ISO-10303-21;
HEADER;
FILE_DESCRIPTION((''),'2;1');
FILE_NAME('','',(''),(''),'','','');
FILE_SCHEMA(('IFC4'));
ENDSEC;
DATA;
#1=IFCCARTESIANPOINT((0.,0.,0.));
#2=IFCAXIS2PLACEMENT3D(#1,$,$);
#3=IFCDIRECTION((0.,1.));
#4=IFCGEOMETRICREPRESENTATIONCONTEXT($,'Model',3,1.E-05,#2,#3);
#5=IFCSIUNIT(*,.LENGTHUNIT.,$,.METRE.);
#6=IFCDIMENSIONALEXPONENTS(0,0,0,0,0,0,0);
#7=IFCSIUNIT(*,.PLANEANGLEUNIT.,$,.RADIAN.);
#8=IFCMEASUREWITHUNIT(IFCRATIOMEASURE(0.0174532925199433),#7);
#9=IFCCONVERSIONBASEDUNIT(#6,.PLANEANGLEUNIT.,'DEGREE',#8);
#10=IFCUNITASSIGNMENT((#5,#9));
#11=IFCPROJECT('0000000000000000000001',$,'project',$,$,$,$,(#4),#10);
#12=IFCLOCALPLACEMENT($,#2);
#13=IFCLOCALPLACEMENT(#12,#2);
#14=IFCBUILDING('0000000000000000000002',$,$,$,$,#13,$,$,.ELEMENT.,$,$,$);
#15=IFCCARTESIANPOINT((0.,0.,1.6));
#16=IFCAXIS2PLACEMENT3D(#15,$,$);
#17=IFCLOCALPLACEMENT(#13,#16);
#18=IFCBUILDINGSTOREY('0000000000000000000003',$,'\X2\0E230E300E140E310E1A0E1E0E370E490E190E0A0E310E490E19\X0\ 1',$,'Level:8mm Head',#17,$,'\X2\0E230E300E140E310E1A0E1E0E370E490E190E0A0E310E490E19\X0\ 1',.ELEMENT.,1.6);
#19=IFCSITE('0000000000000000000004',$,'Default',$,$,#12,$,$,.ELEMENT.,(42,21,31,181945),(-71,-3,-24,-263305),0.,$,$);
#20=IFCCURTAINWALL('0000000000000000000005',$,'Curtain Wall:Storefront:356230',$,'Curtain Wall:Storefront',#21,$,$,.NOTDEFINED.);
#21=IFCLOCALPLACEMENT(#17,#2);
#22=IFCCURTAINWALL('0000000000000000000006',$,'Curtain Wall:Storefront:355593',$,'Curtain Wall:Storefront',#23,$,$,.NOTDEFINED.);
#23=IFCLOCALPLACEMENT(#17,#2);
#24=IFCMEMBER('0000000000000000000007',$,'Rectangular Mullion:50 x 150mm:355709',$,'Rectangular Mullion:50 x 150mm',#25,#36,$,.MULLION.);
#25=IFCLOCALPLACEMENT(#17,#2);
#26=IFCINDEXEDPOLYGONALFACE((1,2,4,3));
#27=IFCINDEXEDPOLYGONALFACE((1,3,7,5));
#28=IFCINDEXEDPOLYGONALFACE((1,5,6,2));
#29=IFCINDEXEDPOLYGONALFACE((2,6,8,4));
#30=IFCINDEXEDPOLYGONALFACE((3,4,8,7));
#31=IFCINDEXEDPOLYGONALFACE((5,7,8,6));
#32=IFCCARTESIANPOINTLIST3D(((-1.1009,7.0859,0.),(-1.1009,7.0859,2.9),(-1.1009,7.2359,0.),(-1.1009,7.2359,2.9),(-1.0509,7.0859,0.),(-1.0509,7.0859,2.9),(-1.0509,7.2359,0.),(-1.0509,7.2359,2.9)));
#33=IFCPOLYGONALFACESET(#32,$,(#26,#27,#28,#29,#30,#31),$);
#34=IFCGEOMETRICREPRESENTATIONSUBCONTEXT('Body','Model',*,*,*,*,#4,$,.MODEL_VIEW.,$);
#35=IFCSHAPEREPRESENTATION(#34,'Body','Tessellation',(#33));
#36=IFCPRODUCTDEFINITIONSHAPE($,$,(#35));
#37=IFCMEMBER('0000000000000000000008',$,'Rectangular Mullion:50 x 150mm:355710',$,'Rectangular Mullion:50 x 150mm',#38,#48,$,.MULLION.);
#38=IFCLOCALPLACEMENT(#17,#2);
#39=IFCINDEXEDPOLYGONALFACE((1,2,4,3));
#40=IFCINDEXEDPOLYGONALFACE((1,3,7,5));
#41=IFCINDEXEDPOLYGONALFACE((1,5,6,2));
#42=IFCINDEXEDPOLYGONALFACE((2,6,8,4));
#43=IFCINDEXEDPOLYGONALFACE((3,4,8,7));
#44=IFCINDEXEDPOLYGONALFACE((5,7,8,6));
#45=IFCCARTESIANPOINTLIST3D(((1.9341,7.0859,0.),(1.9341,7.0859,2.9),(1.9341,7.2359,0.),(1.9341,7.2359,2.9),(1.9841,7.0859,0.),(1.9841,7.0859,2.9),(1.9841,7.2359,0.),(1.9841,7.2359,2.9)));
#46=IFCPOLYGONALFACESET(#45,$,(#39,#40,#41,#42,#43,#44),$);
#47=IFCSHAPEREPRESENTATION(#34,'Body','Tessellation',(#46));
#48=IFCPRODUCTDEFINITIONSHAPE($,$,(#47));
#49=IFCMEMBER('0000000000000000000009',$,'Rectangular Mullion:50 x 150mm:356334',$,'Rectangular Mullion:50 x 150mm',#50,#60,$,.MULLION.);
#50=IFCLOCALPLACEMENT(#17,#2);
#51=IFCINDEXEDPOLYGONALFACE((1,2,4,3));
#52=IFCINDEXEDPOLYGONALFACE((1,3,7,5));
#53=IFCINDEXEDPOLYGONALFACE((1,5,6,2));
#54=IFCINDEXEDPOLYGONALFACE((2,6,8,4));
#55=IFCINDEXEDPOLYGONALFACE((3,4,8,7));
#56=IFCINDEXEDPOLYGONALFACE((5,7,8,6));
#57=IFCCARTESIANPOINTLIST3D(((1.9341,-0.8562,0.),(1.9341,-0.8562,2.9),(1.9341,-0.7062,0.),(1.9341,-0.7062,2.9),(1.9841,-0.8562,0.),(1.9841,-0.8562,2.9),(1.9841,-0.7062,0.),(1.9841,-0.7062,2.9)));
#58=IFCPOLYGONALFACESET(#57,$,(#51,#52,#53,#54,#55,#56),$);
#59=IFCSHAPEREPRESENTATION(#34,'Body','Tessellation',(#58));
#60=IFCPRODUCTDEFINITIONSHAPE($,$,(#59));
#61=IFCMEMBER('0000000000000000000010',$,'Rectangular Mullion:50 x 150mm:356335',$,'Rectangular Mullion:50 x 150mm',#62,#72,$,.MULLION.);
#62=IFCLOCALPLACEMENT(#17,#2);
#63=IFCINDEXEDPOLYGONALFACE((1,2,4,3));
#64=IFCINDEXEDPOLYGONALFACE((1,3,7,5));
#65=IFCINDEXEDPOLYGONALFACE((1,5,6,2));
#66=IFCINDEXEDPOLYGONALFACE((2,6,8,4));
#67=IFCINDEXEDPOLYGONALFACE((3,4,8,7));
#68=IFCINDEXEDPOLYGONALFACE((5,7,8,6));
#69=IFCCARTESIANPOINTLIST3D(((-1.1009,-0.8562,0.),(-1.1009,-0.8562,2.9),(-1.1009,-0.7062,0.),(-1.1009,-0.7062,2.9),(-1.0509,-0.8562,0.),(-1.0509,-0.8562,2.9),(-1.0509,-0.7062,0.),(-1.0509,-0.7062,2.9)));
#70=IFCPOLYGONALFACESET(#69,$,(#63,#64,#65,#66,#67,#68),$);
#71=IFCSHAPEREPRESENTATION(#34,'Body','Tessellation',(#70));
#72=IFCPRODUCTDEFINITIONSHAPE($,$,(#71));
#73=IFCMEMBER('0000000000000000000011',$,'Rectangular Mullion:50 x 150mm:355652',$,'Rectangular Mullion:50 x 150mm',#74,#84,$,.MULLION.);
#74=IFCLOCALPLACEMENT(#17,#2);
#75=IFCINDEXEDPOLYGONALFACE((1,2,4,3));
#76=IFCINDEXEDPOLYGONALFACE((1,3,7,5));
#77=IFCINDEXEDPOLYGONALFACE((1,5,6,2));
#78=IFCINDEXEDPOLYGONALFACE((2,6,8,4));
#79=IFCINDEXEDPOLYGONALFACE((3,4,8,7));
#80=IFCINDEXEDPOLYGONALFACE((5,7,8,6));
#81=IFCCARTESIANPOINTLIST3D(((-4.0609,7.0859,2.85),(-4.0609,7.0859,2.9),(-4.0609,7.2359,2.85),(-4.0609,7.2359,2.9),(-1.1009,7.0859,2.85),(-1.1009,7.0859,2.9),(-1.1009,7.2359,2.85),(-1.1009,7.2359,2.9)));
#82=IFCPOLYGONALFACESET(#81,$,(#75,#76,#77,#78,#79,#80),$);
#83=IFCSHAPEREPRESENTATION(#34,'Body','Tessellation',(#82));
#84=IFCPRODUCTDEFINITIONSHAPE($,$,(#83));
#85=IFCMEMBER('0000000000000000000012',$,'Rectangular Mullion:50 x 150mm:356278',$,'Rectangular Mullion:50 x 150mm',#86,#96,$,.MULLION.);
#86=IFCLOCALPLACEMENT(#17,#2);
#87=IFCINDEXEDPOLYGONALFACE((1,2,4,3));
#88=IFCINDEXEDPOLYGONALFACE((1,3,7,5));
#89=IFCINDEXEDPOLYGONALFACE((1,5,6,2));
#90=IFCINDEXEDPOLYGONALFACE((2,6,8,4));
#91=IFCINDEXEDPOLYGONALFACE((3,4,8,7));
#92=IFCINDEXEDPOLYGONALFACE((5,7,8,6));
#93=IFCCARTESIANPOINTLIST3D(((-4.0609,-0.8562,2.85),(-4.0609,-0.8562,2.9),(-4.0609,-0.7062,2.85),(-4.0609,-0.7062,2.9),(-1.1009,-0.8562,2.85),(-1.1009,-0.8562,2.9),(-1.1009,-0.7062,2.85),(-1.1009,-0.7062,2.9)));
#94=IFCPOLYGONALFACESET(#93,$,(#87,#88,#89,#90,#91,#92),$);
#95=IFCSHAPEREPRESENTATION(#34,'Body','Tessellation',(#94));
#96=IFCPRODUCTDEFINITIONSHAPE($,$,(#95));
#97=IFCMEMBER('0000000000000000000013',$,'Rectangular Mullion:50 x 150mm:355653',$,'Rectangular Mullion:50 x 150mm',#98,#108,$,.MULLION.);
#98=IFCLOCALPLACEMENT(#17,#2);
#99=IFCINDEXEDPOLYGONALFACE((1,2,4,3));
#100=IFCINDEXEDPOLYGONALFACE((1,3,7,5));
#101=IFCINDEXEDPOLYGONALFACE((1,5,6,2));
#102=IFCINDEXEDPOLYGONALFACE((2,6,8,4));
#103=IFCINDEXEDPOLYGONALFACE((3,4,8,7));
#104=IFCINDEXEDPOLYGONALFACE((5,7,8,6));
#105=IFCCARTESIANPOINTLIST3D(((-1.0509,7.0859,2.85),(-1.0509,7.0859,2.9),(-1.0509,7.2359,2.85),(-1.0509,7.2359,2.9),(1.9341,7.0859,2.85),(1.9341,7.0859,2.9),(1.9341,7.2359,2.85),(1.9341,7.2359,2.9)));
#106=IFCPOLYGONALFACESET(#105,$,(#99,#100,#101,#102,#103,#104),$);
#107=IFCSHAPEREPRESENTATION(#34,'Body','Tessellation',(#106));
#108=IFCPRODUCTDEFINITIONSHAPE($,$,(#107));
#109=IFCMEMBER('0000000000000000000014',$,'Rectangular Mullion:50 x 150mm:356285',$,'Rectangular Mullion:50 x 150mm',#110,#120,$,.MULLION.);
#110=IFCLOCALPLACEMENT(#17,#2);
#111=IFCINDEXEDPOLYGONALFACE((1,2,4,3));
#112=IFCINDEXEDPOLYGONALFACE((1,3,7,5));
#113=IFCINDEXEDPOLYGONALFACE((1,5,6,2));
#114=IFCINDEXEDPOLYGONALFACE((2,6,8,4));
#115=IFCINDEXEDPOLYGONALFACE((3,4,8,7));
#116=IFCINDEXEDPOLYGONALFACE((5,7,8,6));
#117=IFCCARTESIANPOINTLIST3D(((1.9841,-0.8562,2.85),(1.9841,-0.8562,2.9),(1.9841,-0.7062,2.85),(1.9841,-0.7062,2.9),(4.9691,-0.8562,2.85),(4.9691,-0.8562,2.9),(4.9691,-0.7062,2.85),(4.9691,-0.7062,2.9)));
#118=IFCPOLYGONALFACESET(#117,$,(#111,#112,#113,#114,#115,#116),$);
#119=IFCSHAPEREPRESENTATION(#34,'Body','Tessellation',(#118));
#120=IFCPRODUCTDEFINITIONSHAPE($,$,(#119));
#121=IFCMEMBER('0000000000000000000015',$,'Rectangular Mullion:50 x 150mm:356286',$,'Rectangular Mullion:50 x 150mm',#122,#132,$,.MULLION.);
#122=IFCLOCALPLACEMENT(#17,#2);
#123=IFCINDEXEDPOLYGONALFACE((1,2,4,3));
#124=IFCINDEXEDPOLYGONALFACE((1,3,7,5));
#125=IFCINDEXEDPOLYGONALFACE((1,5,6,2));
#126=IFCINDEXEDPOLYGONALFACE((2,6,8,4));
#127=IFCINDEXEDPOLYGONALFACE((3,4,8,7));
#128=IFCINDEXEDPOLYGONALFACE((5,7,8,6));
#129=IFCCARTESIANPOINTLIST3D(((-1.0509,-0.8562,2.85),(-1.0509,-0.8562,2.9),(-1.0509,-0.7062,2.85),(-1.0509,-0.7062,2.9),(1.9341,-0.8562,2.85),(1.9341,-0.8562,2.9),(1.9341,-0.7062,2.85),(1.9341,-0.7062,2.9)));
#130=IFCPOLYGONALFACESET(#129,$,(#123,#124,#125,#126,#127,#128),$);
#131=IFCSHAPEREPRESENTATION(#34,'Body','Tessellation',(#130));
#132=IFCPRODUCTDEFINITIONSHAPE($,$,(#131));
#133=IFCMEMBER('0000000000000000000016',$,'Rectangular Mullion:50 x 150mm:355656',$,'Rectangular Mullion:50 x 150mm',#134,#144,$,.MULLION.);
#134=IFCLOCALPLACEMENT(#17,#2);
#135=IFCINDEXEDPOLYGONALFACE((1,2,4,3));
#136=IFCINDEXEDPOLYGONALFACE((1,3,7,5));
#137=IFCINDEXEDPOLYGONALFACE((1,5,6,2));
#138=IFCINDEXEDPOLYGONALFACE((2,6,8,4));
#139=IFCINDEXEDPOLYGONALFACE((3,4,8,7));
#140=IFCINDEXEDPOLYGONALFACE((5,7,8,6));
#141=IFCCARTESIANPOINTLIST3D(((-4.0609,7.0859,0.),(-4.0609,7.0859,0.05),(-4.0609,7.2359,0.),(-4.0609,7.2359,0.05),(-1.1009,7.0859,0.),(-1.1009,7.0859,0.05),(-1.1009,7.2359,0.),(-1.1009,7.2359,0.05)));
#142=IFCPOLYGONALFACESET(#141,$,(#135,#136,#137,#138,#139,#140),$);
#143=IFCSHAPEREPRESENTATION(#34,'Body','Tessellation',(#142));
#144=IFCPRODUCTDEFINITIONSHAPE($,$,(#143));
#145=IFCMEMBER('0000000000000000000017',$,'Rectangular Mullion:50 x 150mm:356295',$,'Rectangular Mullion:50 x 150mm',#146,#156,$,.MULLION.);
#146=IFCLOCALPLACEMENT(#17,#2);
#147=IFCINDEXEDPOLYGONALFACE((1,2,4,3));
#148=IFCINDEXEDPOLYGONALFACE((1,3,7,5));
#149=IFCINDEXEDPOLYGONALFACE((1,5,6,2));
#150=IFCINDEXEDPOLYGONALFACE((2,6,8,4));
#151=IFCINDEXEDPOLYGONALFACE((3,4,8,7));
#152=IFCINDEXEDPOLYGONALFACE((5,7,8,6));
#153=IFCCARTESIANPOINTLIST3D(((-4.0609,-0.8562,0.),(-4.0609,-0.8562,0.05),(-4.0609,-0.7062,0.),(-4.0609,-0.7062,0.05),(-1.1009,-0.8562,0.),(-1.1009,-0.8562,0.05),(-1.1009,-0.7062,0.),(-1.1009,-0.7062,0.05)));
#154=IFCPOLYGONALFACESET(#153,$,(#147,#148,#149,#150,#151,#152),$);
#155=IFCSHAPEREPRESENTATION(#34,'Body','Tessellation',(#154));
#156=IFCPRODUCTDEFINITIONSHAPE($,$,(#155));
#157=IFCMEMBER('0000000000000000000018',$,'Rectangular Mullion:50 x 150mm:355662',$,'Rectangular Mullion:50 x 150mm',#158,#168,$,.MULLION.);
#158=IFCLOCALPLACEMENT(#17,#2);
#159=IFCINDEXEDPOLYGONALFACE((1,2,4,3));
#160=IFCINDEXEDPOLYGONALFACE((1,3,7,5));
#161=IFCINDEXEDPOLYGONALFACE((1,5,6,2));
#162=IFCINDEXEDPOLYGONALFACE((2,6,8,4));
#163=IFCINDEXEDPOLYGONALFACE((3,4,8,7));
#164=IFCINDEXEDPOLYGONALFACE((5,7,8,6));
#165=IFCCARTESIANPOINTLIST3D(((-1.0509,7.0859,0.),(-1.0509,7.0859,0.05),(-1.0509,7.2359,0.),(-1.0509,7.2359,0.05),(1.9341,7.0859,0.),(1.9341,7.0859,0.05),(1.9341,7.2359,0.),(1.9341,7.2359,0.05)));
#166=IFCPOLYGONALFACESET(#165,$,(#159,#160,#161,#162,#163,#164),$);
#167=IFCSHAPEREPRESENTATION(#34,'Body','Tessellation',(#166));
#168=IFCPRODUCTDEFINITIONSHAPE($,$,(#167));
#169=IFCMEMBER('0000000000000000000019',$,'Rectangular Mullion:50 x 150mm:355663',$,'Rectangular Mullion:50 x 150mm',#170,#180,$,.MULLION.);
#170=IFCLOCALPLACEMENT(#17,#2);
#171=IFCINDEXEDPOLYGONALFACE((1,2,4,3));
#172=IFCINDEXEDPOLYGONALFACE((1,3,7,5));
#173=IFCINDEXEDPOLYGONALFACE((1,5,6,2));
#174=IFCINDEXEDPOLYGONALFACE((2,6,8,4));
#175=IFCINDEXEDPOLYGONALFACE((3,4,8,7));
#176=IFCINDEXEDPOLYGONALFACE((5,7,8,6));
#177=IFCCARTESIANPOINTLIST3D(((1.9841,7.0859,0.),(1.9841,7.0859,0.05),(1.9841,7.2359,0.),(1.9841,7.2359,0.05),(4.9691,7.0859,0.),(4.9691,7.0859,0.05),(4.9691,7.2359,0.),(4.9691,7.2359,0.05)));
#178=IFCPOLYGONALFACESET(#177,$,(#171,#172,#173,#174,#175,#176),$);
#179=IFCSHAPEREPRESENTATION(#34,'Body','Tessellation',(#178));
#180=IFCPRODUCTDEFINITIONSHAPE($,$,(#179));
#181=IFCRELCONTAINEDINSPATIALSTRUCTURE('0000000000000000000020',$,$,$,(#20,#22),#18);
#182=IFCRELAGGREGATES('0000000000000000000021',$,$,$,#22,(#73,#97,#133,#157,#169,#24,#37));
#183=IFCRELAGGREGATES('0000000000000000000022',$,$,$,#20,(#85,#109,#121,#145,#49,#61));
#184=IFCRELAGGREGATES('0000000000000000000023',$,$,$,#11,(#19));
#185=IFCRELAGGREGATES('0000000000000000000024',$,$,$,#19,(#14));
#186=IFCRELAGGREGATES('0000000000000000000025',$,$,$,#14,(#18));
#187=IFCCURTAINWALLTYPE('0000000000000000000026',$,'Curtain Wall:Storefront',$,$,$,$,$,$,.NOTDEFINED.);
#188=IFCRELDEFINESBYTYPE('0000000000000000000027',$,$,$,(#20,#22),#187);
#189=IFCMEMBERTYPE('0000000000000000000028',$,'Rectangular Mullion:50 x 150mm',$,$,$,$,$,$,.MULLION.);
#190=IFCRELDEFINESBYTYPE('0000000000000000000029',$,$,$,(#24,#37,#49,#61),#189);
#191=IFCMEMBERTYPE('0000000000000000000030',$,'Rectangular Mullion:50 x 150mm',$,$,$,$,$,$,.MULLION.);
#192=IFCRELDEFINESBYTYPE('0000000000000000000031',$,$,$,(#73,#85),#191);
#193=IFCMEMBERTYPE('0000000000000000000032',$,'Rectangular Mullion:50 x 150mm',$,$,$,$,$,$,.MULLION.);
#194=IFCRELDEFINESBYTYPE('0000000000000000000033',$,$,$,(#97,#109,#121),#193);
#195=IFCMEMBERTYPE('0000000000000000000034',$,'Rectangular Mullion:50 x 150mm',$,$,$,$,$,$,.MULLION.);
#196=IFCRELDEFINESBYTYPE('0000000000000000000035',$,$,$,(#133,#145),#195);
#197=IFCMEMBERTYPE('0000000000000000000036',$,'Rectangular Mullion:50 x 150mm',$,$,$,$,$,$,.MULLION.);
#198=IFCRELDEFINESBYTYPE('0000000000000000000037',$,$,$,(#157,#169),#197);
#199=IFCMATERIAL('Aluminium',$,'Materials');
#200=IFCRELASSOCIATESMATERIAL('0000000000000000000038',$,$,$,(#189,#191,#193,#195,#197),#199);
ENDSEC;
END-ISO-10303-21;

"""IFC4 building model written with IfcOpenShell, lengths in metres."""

from ifc_helpers import new_model, entity, si_unit, converted_unit, direction, frame, origin, place, context, subcontext, project, spatial, indexed_curve, outline, extrude, source, transform, mapped, material, type_object, type_shapes, element, aggregate, save


model = new_model("IFC4")

# Units and contexts
model_context = context("Model", 3, precision=1e-05, world=origin(), true_north=direction((0.0, 1.0)))
body_context = subcontext(model_context, "Body", "Model", "MODEL_VIEW")
ifc_project = project(units=[si_unit("LENGTHUNIT", "METRE"), converted_unit("PLANEANGLEUNIT", "DEGREE", entity("IfcRatioMeasure", 0.0174532925199433), si_unit("PLANEANGLEUNIT", "RADIAN"), dimensions=[0, 0, 0, 0, 0, 0, 0])], contexts=[model_context])

# Site, building, storey
site_placement = place(None, origin())
site = spatial("IfcSite", under=ifc_project, at=site_placement, Name="Default", CompositionType="ELEMENT", RefLatitude=(42, 21, 31, 181945), RefLongitude=(-71, -3, -24, -263305), RefElevation=0.0)
building_placement = place(site_placement, origin())
building = spatial("IfcBuilding", under=site, at=building_placement, CompositionType="ELEMENT")
storey_placement = place(building_placement, frame((0.0, 0.0, 1.6)))
storey = spatial("IfcBuildingStorey", under=building, at=storey_placement, Name="ระดับพื้นชั้น 1", ObjectType="Level:8mm Head", LongName="ระดับพื้นชั้น 1", CompositionType="ELEMENT", Elevation=1.6)

# Shared definitions
curtain_wall_type = type_object("IfcCurtainWallType", Name="Curtain Wall:Storefront", PredefinedType="NOTDEFINED")
ifc_material_1 = material(Name="Aluminium", Category="Materials")

# Curtain wall
curtain_wall_1_placement = place(storey_placement, frame((0.0, 0.0, -1.6)))
curtain_wall_1 = element("IfcCurtainWall", 1, at=curtain_wall_1_placement, inside=storey, type_object=curtain_wall_type, Name="Curtain Wall:Storefront:356230", ObjectType="Curtain Wall:Storefront", PredefinedType="NOTDEFINED")

# Curtain wall
curtain_wall_2_placement = place(storey_placement, frame((0.0, 0.0, -1.6)))
curtain_wall_2 = element("IfcCurtainWall", 2, at=curtain_wall_2_placement, inside=storey, type_object=curtain_wall_type, Name="Curtain Wall:Storefront:355593", ObjectType="Curtain Wall:Storefront", PredefinedType="NOTDEFINED")

# Members
member_type_1 = type_object("IfcMemberType", Name="Rectangular Mullion:50 x 150mm", PredefinedType="MULLION", material=ifc_material_1)
shared_shape_1 = source(origin(), body_context, "Body", "SweptSolid", [
    extrude(outline(indexed_curve([(-0.075, -0.025), (0.075, -0.025), (0.075, 0.025), (-0.075, 0.025), (-0.075, -0.025)], self_intersect=False)), frame((0.0, 0.0, -2.9), z_axis=(0.0, 0.0, 1.0), x_axis=(0.0, -1.0, 0.0)), (0.0, 0.0, 1.0), 2.9),
])
type_shapes(member_type_1, [shared_shape_1])
member_1_placement = place(curtain_wall_2_placement, frame((-1.0759, 7.1609, 1.6), z_axis=(0.0, 0.0, -1.0), x_axis=(1.0, 0.0, 0.0)))
member_1 = element("IfcMember", 3, at=member_1_placement, type_object=member_type_1, Name="Rectangular Mullion:50 x 150mm:355709", ObjectType="Rectangular Mullion:50 x 150mm", PredefinedType="MULLION", context=body_context, shape_type="MappedRepresentation", body=[
    mapped(shared_shape_1, transform((0.0, 0.0, 0.0), scale=1.0)),
])
member_2_placement = place(curtain_wall_2_placement, frame((1.9591, 7.1609, 1.6), z_axis=(0.0, 0.0, -1.0), x_axis=(1.0, 0.0, 0.0)))
member_2 = element("IfcMember", 4, at=member_2_placement, type_object=member_type_1, Name="Rectangular Mullion:50 x 150mm:355710", ObjectType="Rectangular Mullion:50 x 150mm", PredefinedType="MULLION", context=body_context, shape_type="MappedRepresentation", body=[
    mapped(shared_shape_1, transform((0.0, 0.0, 0.0), scale=1.0)),
])
member_3_placement = place(curtain_wall_1_placement, frame((1.9591, -0.7812, 1.6), z_axis=(0.0, 0.0, -1.0), x_axis=(-1.0, 0.0, 0.0)))
member_3 = element("IfcMember", 5, at=member_3_placement, type_object=member_type_1, Name="Rectangular Mullion:50 x 150mm:356334", ObjectType="Rectangular Mullion:50 x 150mm", PredefinedType="MULLION", context=body_context, shape_type="MappedRepresentation", body=[
    mapped(shared_shape_1, transform((0.0, 0.0, 0.0), scale=1.0)),
])
member_4_placement = place(curtain_wall_1_placement, frame((-1.0759, -0.7812, 1.6), z_axis=(0.0, 0.0, -1.0), x_axis=(-1.0, 0.0, 0.0)))
member_4 = element("IfcMember", 6, at=member_4_placement, type_object=member_type_1, Name="Rectangular Mullion:50 x 150mm:356335", ObjectType="Rectangular Mullion:50 x 150mm", PredefinedType="MULLION", context=body_context, shape_type="MappedRepresentation", body=[
    mapped(shared_shape_1, transform((0.0, 0.0, 0.0), scale=1.0)),
])
member_type_2 = type_object("IfcMemberType", Name="Rectangular Mullion:50 x 150mm", PredefinedType="MULLION", material=ifc_material_1)
shared_shape_2 = source(origin(), body_context, "Body", "SweptSolid", [
    extrude(outline(indexed_curve([(-0.075, -0.025), (0.075, -0.025), (0.075, 0.025), (-0.075, 0.025), (-0.075, -0.025)], self_intersect=False)), frame((-0.025, 0.0, -2.96), z_axis=(0.0, 0.0, 1.0), x_axis=(0.0, -1.0, 0.0)), (0.0, 0.0, 1.0), 2.96),
])
type_shapes(member_type_2, [shared_shape_2])
member_5_placement = place(curtain_wall_2_placement, frame((-1.1009, 7.1609, 4.5), z_axis=(1.0, 0.0, 0.0), x_axis=(0.0, 0.0, 1.0)))
member_5 = element("IfcMember", 7, at=member_5_placement, type_object=member_type_2, Name="Rectangular Mullion:50 x 150mm:355652", ObjectType="Rectangular Mullion:50 x 150mm", PredefinedType="MULLION", context=body_context, shape_type="MappedRepresentation", body=[
    mapped(shared_shape_2, transform((0.0, 0.0, 0.0), scale=1.0)),
])
member_6_placement = place(curtain_wall_1_placement, frame((-4.0609, -0.7812, 4.5), z_axis=(-1.0, 0.0, 0.0), x_axis=(0.0, 0.0, 1.0)))
member_6 = element("IfcMember", 8, at=member_6_placement, type_object=member_type_2, Name="Rectangular Mullion:50 x 150mm:356278", ObjectType="Rectangular Mullion:50 x 150mm", PredefinedType="MULLION", context=body_context, shape_type="MappedRepresentation", body=[
    mapped(shared_shape_2, transform((0.0, 0.0, 0.0), scale=1.0)),
])
member_type_3 = type_object("IfcMemberType", Name="Rectangular Mullion:50 x 150mm", PredefinedType="MULLION", material=ifc_material_1)
shared_shape_3 = source(origin(), body_context, "Body", "SweptSolid", [
    extrude(outline(indexed_curve([(-0.075, -0.025), (0.075, -0.025), (0.075, 0.025), (-0.075, 0.025), (-0.075, -0.025)], self_intersect=False)), frame((-0.025, 0.0, -2.985), z_axis=(0.0, 0.0, 1.0), x_axis=(0.0, -1.0, 0.0)), (0.0, 0.0, 1.0), 2.985),
])
type_shapes(member_type_3, [shared_shape_3])
member_7_placement = place(curtain_wall_2_placement, frame((1.9341, 7.1609, 4.5), z_axis=(1.0, 0.0, 0.0), x_axis=(0.0, 0.0, 1.0)))
member_7 = element("IfcMember", 9, at=member_7_placement, type_object=member_type_3, Name="Rectangular Mullion:50 x 150mm:355653", ObjectType="Rectangular Mullion:50 x 150mm", PredefinedType="MULLION", context=body_context, shape_type="MappedRepresentation", body=[
    mapped(shared_shape_3, transform((0.0, 0.0, 0.0), scale=1.0)),
])
member_8_placement = place(curtain_wall_1_placement, frame((1.9841, -0.7812, 4.5), z_axis=(-1.0, 0.0, 0.0), x_axis=(0.0, 0.0, 1.0)))
member_8 = element("IfcMember", 10, at=member_8_placement, type_object=member_type_3, Name="Rectangular Mullion:50 x 150mm:356285", ObjectType="Rectangular Mullion:50 x 150mm", PredefinedType="MULLION", context=body_context, shape_type="MappedRepresentation", body=[
    mapped(shared_shape_3, transform((0.0, 0.0, 0.0), scale=1.0)),
])
member_9_placement = place(curtain_wall_1_placement, frame((-1.0509, -0.7812, 4.5), z_axis=(-1.0, 0.0, 0.0), x_axis=(0.0, 0.0, 1.0)))
member_9 = element("IfcMember", 11, at=member_9_placement, type_object=member_type_3, Name="Rectangular Mullion:50 x 150mm:356286", ObjectType="Rectangular Mullion:50 x 150mm", PredefinedType="MULLION", context=body_context, shape_type="MappedRepresentation", body=[
    mapped(shared_shape_3, transform((0.0, 0.0, 0.0), scale=1.0)),
])
member_type_4 = type_object("IfcMemberType", Name="Rectangular Mullion:50 x 150mm", PredefinedType="MULLION", material=ifc_material_1)
shared_shape_4 = source(origin(), body_context, "Body", "SweptSolid", [
    extrude(outline(indexed_curve([(-0.075, -0.025), (0.075, -0.025), (0.075, 0.025), (-0.075, 0.025), (-0.075, -0.025)], self_intersect=False)), frame((-0.025, 0.0, -2.96), z_axis=(0.0, 0.0, 1.0), x_axis=(0.0, -1.0, 0.0)), (0.0, 0.0, 1.0), 2.96),
])
type_shapes(member_type_4, [shared_shape_4])
member_10_placement = place(curtain_wall_2_placement, frame((-4.0609, 7.1609, 1.6), z_axis=(-1.0, 0.0, 0.0), x_axis=(0.0, 0.0, -1.0)))
member_10 = element("IfcMember", 12, at=member_10_placement, type_object=member_type_4, Name="Rectangular Mullion:50 x 150mm:355656", ObjectType="Rectangular Mullion:50 x 150mm", PredefinedType="MULLION", context=body_context, shape_type="MappedRepresentation", body=[
    mapped(shared_shape_4, transform((0.0, 0.0, 0.0), scale=1.0)),
])
member_11_placement = place(curtain_wall_1_placement, frame((-1.1009, -0.7812, 1.6), z_axis=(1.0, 0.0, 0.0), x_axis=(0.0, 0.0, -1.0)))
member_11 = element("IfcMember", 13, at=member_11_placement, type_object=member_type_4, Name="Rectangular Mullion:50 x 150mm:356295", ObjectType="Rectangular Mullion:50 x 150mm", PredefinedType="MULLION", context=body_context, shape_type="MappedRepresentation", body=[
    mapped(shared_shape_4, transform((0.0, 0.0, 0.0), scale=1.0)),
])
member_type_5 = type_object("IfcMemberType", Name="Rectangular Mullion:50 x 150mm", PredefinedType="MULLION", material=ifc_material_1)
shared_shape_5 = source(origin(), body_context, "Body", "SweptSolid", [
    extrude(outline(indexed_curve([(-0.075, -0.025), (0.075, -0.025), (0.075, 0.025), (-0.075, 0.025), (-0.075, -0.025)], self_intersect=False)), frame((-0.025, 0.0, -2.985), z_axis=(0.0, 0.0, 1.0), x_axis=(0.0, -1.0, 0.0)), (0.0, 0.0, 1.0), 2.985),
])
type_shapes(member_type_5, [shared_shape_5])
member_12_placement = place(curtain_wall_2_placement, frame((-1.0509, 7.1609, 1.6), z_axis=(-1.0, 0.0, 0.0), x_axis=(0.0, 0.0, -1.0)))
member_12 = element("IfcMember", 14, at=member_12_placement, type_object=member_type_5, Name="Rectangular Mullion:50 x 150mm:355662", ObjectType="Rectangular Mullion:50 x 150mm", PredefinedType="MULLION", context=body_context, shape_type="MappedRepresentation", body=[
    mapped(shared_shape_5, transform((0.0, 0.0, 0.0), scale=1.0)),
])
member_13_placement = place(curtain_wall_2_placement, frame((1.9841, 7.1609, 1.6), z_axis=(-1.0, 0.0, 0.0), x_axis=(0.0, 0.0, -1.0)))
member_13 = element("IfcMember", 15, at=member_13_placement, type_object=member_type_5, Name="Rectangular Mullion:50 x 150mm:355663", ObjectType="Rectangular Mullion:50 x 150mm", PredefinedType="MULLION", context=body_context, shape_type="MappedRepresentation", body=[
    mapped(shared_shape_5, transform((0.0, 0.0, 0.0), scale=1.0)),
])

aggregate(curtain_wall_2, [member_5, member_7, member_10, member_12, member_13, member_1, member_2])
aggregate(curtain_wall_1, [member_6, member_8, member_9, member_11, member_3, member_4])

save(model, "model.ifc")
